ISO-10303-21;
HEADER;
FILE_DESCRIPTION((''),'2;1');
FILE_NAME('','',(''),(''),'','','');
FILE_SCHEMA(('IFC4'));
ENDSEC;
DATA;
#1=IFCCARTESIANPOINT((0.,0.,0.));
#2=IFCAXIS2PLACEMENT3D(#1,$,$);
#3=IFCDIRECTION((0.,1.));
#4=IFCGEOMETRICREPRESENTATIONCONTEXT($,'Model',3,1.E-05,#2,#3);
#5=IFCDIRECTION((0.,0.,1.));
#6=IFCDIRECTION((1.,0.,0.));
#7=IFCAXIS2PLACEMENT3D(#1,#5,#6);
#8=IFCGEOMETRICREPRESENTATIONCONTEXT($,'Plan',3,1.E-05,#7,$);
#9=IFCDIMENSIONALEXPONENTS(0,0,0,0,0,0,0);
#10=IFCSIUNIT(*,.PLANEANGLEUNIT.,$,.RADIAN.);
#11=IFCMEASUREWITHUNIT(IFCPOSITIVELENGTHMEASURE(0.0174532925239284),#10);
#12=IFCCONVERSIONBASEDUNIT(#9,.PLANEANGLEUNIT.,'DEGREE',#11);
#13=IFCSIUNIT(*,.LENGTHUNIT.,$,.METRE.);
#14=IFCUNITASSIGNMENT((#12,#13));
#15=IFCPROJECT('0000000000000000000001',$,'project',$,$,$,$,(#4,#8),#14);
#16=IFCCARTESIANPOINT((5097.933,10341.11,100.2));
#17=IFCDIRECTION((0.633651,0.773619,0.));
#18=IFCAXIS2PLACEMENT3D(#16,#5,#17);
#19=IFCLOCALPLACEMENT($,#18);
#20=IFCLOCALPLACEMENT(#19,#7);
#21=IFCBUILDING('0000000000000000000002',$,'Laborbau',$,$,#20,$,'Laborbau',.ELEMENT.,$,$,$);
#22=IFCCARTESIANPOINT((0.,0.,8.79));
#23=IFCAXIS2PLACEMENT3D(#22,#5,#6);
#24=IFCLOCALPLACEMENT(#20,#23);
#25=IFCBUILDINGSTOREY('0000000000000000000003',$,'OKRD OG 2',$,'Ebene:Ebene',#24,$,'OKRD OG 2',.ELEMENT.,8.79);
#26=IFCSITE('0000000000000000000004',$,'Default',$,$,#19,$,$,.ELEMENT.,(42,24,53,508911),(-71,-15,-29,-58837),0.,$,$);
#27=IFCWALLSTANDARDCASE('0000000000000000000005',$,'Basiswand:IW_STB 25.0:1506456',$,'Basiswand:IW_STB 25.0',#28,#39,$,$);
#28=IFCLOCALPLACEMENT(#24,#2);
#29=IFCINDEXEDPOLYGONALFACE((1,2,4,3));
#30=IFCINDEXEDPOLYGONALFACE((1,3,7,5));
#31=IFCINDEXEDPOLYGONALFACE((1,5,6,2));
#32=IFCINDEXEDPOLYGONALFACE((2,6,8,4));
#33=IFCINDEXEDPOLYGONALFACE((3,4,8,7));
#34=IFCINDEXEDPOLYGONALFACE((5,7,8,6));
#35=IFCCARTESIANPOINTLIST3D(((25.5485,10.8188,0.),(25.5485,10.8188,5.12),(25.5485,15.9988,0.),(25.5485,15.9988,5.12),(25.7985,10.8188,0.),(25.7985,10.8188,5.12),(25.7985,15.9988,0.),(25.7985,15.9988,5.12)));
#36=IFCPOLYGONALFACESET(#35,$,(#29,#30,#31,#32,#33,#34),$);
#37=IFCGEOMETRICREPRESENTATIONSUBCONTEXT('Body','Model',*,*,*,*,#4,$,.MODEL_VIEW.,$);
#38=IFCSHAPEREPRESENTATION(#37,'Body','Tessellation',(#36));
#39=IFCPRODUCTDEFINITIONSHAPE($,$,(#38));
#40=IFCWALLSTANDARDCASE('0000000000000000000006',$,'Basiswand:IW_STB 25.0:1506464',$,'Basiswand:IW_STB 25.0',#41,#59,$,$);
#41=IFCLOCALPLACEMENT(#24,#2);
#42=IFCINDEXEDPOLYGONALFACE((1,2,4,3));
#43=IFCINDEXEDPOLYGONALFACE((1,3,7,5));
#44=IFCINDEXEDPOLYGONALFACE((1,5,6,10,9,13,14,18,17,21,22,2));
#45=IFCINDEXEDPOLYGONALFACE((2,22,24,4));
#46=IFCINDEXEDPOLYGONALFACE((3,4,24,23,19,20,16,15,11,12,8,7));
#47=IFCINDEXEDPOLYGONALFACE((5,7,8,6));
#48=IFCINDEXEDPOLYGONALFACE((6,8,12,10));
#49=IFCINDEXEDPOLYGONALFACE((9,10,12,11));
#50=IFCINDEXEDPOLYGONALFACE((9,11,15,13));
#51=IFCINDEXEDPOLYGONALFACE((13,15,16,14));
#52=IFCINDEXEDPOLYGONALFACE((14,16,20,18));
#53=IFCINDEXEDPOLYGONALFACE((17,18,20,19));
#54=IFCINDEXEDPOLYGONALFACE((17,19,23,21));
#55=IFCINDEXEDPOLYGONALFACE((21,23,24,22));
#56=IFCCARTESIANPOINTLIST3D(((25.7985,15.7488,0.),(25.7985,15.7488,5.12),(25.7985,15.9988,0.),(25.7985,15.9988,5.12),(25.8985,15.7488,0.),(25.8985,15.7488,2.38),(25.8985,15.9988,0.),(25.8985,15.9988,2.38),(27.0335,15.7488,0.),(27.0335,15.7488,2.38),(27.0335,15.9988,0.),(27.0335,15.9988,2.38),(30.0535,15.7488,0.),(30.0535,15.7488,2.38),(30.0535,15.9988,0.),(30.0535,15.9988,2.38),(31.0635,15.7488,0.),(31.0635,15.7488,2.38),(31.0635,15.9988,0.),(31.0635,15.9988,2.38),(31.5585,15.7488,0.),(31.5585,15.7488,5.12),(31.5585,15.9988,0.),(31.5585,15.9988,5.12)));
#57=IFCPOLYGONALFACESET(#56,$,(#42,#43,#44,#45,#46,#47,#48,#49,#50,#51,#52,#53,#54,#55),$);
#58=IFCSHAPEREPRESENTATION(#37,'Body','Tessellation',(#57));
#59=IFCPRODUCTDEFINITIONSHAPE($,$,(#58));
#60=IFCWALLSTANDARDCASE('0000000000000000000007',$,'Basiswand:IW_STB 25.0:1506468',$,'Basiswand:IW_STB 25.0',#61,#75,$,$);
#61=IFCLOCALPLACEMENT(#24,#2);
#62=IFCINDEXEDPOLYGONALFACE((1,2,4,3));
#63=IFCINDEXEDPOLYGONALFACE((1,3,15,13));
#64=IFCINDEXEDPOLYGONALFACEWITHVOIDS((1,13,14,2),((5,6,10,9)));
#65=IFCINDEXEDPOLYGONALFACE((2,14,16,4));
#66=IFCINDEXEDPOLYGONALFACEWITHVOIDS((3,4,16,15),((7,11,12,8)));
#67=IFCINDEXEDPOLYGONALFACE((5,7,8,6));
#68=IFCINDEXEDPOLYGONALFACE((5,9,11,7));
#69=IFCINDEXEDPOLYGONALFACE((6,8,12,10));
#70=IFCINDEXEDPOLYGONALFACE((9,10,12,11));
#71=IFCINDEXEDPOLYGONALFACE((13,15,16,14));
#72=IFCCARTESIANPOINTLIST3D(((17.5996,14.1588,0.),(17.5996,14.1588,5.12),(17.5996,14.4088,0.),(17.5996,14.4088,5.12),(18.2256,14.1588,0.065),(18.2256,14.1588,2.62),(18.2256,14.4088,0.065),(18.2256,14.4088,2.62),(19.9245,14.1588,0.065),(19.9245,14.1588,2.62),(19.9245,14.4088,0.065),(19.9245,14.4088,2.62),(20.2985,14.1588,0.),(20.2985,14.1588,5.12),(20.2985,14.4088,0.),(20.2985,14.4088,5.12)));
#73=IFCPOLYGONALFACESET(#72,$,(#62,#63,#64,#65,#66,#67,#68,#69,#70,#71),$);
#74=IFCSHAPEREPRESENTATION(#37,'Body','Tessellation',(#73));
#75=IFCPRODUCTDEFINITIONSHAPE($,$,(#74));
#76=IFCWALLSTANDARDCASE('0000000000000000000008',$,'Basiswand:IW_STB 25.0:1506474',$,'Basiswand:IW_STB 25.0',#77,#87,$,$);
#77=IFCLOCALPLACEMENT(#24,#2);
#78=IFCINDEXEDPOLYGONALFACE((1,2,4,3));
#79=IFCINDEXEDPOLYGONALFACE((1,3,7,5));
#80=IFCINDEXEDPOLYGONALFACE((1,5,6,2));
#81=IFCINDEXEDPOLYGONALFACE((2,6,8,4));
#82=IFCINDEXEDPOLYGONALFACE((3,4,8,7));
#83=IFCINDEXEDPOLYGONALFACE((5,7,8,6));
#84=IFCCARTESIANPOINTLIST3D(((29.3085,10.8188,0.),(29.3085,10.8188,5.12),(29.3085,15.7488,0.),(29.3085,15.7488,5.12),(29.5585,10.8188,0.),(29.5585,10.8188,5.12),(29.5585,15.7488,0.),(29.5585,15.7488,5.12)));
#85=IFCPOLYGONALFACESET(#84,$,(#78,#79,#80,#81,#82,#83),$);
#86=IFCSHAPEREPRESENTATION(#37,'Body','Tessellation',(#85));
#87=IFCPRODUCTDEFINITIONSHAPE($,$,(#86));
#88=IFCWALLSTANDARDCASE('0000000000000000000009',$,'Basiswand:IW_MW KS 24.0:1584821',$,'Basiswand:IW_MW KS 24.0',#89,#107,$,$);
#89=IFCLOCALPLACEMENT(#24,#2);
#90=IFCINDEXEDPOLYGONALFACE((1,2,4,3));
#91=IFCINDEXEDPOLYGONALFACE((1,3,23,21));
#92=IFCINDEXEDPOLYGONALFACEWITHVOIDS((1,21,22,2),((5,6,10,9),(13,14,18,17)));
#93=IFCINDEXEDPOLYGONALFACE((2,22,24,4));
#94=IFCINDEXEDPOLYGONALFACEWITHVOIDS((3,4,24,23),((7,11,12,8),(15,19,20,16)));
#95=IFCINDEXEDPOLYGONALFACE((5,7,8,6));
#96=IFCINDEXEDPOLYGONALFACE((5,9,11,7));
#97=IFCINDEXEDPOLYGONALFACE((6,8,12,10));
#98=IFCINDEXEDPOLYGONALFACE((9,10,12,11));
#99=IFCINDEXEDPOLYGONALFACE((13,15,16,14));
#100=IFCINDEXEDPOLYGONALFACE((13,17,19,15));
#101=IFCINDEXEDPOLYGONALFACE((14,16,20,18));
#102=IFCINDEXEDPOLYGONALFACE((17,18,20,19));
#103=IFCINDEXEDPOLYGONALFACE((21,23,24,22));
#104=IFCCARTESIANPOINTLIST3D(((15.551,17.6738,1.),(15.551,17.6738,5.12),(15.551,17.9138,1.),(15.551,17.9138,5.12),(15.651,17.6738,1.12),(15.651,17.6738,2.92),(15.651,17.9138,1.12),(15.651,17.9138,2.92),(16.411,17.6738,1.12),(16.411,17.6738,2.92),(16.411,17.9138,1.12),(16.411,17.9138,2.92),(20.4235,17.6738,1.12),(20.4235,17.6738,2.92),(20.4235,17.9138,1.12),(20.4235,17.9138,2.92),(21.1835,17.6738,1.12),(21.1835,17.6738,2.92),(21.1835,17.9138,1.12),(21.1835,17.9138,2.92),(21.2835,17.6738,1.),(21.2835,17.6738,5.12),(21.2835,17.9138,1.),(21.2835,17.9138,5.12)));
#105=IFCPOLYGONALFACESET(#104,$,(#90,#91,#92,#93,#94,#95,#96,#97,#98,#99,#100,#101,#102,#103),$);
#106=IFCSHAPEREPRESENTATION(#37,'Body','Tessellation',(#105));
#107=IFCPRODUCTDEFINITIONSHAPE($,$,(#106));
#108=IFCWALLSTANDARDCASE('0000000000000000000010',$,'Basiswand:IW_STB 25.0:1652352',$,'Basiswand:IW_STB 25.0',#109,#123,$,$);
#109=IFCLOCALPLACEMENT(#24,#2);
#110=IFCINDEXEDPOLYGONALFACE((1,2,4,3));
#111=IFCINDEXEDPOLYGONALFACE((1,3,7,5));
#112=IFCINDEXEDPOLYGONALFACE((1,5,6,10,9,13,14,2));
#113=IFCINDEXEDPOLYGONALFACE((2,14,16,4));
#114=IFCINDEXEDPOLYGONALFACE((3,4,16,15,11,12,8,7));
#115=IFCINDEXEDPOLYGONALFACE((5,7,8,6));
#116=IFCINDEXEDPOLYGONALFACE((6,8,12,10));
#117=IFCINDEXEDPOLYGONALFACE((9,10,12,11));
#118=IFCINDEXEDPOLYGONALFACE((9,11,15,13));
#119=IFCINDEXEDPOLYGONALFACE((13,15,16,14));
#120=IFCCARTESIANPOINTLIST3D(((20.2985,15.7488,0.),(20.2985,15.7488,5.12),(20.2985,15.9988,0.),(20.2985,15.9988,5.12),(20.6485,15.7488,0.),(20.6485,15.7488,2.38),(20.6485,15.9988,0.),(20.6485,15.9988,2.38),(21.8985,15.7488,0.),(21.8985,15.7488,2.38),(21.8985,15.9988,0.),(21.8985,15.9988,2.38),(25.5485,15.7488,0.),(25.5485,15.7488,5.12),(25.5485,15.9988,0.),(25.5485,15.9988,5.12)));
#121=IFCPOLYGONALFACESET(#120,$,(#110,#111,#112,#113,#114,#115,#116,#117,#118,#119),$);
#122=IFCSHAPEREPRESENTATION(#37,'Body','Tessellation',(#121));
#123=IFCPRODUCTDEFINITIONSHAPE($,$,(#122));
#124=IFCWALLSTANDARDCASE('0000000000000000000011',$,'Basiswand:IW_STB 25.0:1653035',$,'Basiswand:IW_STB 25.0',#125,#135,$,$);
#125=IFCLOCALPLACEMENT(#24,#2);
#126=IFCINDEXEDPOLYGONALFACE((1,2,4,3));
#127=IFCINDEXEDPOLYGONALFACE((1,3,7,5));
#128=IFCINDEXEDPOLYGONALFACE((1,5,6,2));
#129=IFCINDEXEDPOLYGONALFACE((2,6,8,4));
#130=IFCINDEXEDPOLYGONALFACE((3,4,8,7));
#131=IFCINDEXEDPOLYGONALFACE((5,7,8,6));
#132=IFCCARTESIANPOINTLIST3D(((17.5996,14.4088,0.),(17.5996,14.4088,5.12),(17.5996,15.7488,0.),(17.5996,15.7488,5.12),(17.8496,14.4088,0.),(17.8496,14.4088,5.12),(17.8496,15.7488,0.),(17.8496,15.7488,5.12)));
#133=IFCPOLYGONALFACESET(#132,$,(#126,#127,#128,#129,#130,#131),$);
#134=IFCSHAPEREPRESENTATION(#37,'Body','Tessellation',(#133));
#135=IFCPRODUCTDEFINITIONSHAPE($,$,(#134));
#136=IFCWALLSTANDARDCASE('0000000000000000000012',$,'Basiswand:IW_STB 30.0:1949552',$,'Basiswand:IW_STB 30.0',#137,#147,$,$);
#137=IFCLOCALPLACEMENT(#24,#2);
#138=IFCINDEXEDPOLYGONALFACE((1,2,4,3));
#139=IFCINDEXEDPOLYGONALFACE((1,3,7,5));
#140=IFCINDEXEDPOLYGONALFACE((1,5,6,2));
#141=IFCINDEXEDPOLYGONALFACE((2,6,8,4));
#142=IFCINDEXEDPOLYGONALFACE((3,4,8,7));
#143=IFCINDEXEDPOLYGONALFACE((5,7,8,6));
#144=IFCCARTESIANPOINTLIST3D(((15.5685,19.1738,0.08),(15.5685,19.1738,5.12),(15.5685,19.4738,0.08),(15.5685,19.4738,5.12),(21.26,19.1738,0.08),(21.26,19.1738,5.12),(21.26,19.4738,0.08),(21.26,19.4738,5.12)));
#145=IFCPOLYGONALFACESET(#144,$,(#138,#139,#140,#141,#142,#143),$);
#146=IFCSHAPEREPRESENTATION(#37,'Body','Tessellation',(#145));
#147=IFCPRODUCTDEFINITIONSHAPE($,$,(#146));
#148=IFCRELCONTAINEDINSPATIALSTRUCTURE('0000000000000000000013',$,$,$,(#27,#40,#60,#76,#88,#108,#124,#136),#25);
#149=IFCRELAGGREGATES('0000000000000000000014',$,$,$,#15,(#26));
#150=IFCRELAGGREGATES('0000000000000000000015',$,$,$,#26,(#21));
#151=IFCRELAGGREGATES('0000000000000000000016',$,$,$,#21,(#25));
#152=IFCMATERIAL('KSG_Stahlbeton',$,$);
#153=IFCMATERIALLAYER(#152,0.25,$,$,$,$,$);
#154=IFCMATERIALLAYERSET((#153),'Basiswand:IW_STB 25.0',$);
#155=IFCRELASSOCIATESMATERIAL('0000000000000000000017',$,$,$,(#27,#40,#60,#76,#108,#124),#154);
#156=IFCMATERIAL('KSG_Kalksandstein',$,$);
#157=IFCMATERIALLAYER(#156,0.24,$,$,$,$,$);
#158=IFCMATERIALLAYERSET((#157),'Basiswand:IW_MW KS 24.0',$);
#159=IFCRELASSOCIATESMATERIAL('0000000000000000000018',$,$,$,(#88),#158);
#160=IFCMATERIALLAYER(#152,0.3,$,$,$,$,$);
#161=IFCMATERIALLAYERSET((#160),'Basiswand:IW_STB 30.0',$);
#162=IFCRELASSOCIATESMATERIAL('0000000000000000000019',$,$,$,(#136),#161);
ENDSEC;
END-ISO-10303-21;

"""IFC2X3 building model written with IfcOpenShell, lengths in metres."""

from ifc_helpers import new_model, entity, si_unit, converted_unit, direction, frame, frame_2d, origin, origin_with_axes, place, context, subcontext, project, spatial, rectangle, extrude, material, layer, layer_set, layer_usage, element, save


model = new_model("IFC2X3")

# Units and contexts
model_context = context("Model", 3, precision=1e-05, world=origin(), true_north=direction((0.0, 1.0)))
plan_context = context("Plan", 3, precision=1e-05, world=origin_with_axes())
body_context = subcontext(model_context, "Body", "Model", "MODEL_VIEW")
ifc_project = project(units=[converted_unit("PLANEANGLEUNIT", "DEGREE", entity("IfcPositiveLengthMeasure", 0.0174532925239284), si_unit("PLANEANGLEUNIT", "RADIAN"), dimensions=[0, 0, 0, 0, 0, 0, 0]), si_unit("LENGTHUNIT", "METRE")], contexts=[model_context, plan_context])

# Site, building, storey
site_placement = place(None, frame((5097.933, 10341.11, 100.2), z_axis=(0.0, 0.0, 1.0), x_axis=(0.633651, 0.773619, 0.0)))
site = spatial("IfcSite", under=ifc_project, at=site_placement, Name="Default", CompositionType="ELEMENT", RefLatitude=(42, 24, 53, 508911), RefLongitude=(-71, -15, -29, -58837), RefElevation=0.0)
building_placement = place(site_placement, origin_with_axes())
building = spatial("IfcBuilding", under=site, at=building_placement, Name="Laborbau", LongName="Laborbau", CompositionType="ELEMENT")
storey_placement = place(building_placement, frame((0.0, 0.0, 8.79), z_axis=(0.0, 0.0, 1.0), x_axis=(1.0, 0.0, 0.0)))
storey = spatial("IfcBuildingStorey", under=building, at=storey_placement, Name="OKRD OG 2", ObjectType="Ebene:Ebene", LongName="OKRD OG 2", CompositionType="ELEMENT", Elevation=8.79)

# Shared definitions
ifc_material_1 = material(Name="KSG_Kalksandstein")
ifc_layer_1 = layer(ifc_material_1, 0.24)
ifc_layer_set_1 = layer_set([ifc_layer_1], Name="Basiswand:IW_MW KS 24.0")

# Wall
ifc_material_2 = material(Name="KSG_Stahlbeton")
ifc_layer_2 = layer(ifc_material_2, 0.25)
ifc_layer_set_2 = layer_set([ifc_layer_2], Name="Basiswand:IW_STB 25.0")
ifc_layer_usage_1 = layer_usage(ifc_layer_set_2, "AXIS2", "NEGATIVE", 0.125)
wall_1_placement = place(storey_placement, frame((25.6735, 10.8188, 0.0), z_axis=(0.0, 0.0, 1.0), x_axis=(0.0, 1.0, 0.0)))
element("IfcWallStandardCase", 1, at=wall_1_placement, inside=storey, material=ifc_layer_usage_1, Name="Basiswand:IW_STB 25.0:1506456", ObjectType="Basiswand:IW_STB 25.0", context=body_context, shape_type="SweptSolid", body=[
    extrude(rectangle(XDim=5.18, YDim=0.25, at=frame_2d((2.59, 0.0), x_axis=(-1.0, 0.0))), origin(), (0.0, 0.0, 1.0), 5.12),
])

# Wall, openings
ifc_layer_usage_2 = layer_usage(ifc_layer_set_2, "AXIS2", "NEGATIVE", 0.125)
wall_2_placement = place(storey_placement, frame((25.7985, 15.8738, 0.0), z_axis=(0.0, 0.0, 1.0), x_axis=(1.0, 0.0, 0.0)))
wall_2 = element("IfcWallStandardCase", 2, at=wall_2_placement, inside=storey, material=ifc_layer_usage_2, Name="Basiswand:IW_STB 25.0:1506464", ObjectType="Basiswand:IW_STB 25.0", context=body_context, shape_type="SweptSolid", body=[
    extrude(rectangle(XDim=5.76, YDim=0.25, at=frame_2d((2.88, 0.0), x_axis=(-1.0, 0.0))), origin(), (0.0, 0.0, 1.0), 5.12),
])
opening_1_placement = place(wall_2_placement, frame((-25.7985, -15.8738, 0.0), z_axis=(0.0, 0.0, 1.0), x_axis=(1.0, 0.0, 0.0)))
element("IfcOpeningElement", 3, at=opening_1_placement, cuts=wall_2, ObjectType="Opening", context=body_context, shape_type="SweptSolid", body=[
    extrude(rectangle(XDim=2.38, YDim=1.135, at=frame_2d((0.0, 0.0), x_axis=(0.0, 1.0))), frame((26.466, 14.4748, 1.19), z_axis=(0.0, 1.0, 0.0), x_axis=(-1.0, 0.0, 0.0)), (0.0, 0.0, 1.0), 3.048),
])
opening_2_placement = place(wall_2_placement, frame((1.235, 0.125, 0.0), z_axis=(0.0, 0.0, 1.0), x_axis=(1.0, 0.0, 0.0)))
element("IfcOpeningElement", 4, at=opening_2_placement, cuts=wall_2, ObjectType="Opening", context=body_context, shape_type="SweptSolid", body=[
    extrude(rectangle(XDim=2.38, YDim=1.135, at=frame_2d((1.19, 0.5675), x_axis=(1.0, 0.0))), frame((0.0, 0.0, 0.0), z_axis=(0.0, -1.0, 0.0), x_axis=(0.0, 0.0, 1.0)), (0.0, 0.0, 1.0), 0.25),
])
opening_3_placement = place(wall_2_placement, frame((-25.7985, -15.8738, 0.0), z_axis=(0.0, 0.0, 1.0), x_axis=(1.0, 0.0, 0.0)))
element("IfcOpeningElement", 5, at=opening_3_placement, cuts=wall_2, ObjectType="Opening", context=body_context, shape_type="SweptSolid", body=[
    extrude(rectangle(XDim=2.38, YDim=1.01, at=frame_2d((0.0, 0.0), x_axis=(0.0, 1.0))), frame((30.5585, 14.2248, 1.19), z_axis=(0.0, 1.0, 0.0), x_axis=(-1.0, 0.0, 0.0)), (0.0, 0.0, 1.0), 3.048),
])
opening_4_placement = place(wall_2_placement, frame((4.255, -0.125, 0.0), z_axis=(0.0, 0.0, 1.0), x_axis=(1.0, 0.0, 0.0)))
element("IfcOpeningElement", 6, at=opening_4_placement, cuts=wall_2, ObjectType="Opening", context=body_context, shape_type="SweptSolid", body=[
    extrude(rectangle(XDim=2.38, YDim=1.01, at=frame_2d((1.19, 0.505), x_axis=(1.0, 0.0))), frame((0.0, 0.0, 0.0), z_axis=(0.0, 1.0, 0.0), x_axis=(0.0, 0.0, 1.0)), (0.0, 0.0, 1.0), 0.25),
])

# Wall, opening
ifc_layer_usage_3 = layer_usage(ifc_layer_set_2, "AXIS2", "NEGATIVE", 0.125)
wall_3_placement = place(storey_placement, frame((17.5996, 14.2838, 0.0), z_axis=(0.0, 0.0, 1.0), x_axis=(1.0, 0.0, 0.0)))
wall_3 = element("IfcWallStandardCase", 7, at=wall_3_placement, inside=storey, material=ifc_layer_usage_3, Name="Basiswand:IW_STB 25.0:1506468", ObjectType="Basiswand:IW_STB 25.0", context=body_context, shape_type="SweptSolid", body=[
    extrude(rectangle(XDim=2.699, YDim=0.25, at=frame_2d((1.3495, 0.0), x_axis=(-1.0, 0.0))), origin(), (0.0, 0.0, 1.0), 5.12),
])
opening_5_placement = place(wall_3_placement, origin_with_axes())
element("IfcOpeningElement", 8, at=opening_5_placement, cuts=wall_3, ObjectType="Opening", context=body_context, shape_type="SweptSolid", body=[
    extrude(rectangle(XDim=2.555, YDim=1.699, at=frame_2d((0.0, 0.0), x_axis=(1.0, 0.0))), frame((1.4755, -0.125, 1.3425), z_axis=(0.0, 1.0, 0.0), x_axis=(0.0, 0.0, -1.0)), (0.0, 0.0, 1.0), 0.25),
])

# Wall
ifc_layer_usage_4 = layer_usage(ifc_layer_set_2, "AXIS2", "NEGATIVE", 0.125)
wall_4_placement = place(storey_placement, frame((29.4335, 10.8188, 0.0), z_axis=(0.0, 0.0, 1.0), x_axis=(0.0, 1.0, 0.0)))
element("IfcWallStandardCase", 9, at=wall_4_placement, inside=storey, material=ifc_layer_usage_4, Name="Basiswand:IW_STB 25.0:1506474", ObjectType="Basiswand:IW_STB 25.0", context=body_context, shape_type="SweptSolid", body=[
    extrude(rectangle(XDim=4.93, YDim=0.25, at=frame_2d((2.465, 0.0), x_axis=(-1.0, 0.0))), origin(), (0.0, 0.0, 1.0), 5.12),
])

# Walls, openings
ifc_layer_usage_5 = layer_usage(ifc_layer_set_1, "AXIS2", "NEGATIVE", 0.12)
wall_5_placement = place(storey_placement, frame((21.2835, 17.7938, 1.0), z_axis=(0.0, 0.0, 1.0), x_axis=(-1.0, 0.0, 0.0)))
wall_5 = element("IfcWallStandardCase", 10, at=wall_5_placement, inside=storey, material=ifc_layer_usage_5, Name="Basiswand:IW_MW KS 24.0:1584821", ObjectType="Basiswand:IW_MW KS 24.0", context=body_context, shape_type="SweptSolid", body=[
    extrude(rectangle(XDim=5.7325, YDim=0.24, at=frame_2d((2.8663, 0.0), x_axis=(-1.0, 0.0))), origin(), (0.0, 0.0, 1.0), 4.12),
])
opening_6_placement = place(wall_5_placement, frame((21.2835, 17.7938, -1.0), z_axis=(0.0, 0.0, 1.0), x_axis=(-1.0, 0.0, 0.0)))
element("IfcOpeningElement", 11, at=opening_6_placement, cuts=wall_5, ObjectType="Opening", context=body_context, shape_type="SweptSolid", body=[
    extrude(rectangle(XDim=1.8, YDim=0.76, at=frame_2d((0.0, 0.0), x_axis=(1.0, 0.0))), frame((16.031, 19.4378, 2.02), z_axis=(0.0, -1.0, 0.0), x_axis=(0.0, 0.0, 1.0)), (0.0, 0.0, 1.0), 3.048),
])
opening_7_placement = place(wall_5_placement, frame((4.8725, -0.12, 0.12), z_axis=(0.0, 0.0, 1.0), x_axis=(1.0, 0.0, 0.0)))
element("IfcOpeningElement", 12, at=opening_7_placement, cuts=wall_5, ObjectType="Opening", context=body_context, shape_type="SweptSolid", body=[
    extrude(rectangle(XDim=1.8, YDim=0.76, at=frame_2d((0.9, 0.38), x_axis=(1.0, 0.0))), frame((0.0, 0.0, 0.0), z_axis=(0.0, 1.0, 0.0), x_axis=(0.0, 0.0, 1.0)), (0.0, 0.0, 1.0), 0.24),
])
opening_8_placement = place(wall_5_placement, frame((21.2835, 17.7938, -1.0), z_axis=(0.0, 0.0, 1.0), x_axis=(-1.0, 0.0, 0.0)))
element("IfcOpeningElement", 13, at=opening_8_placement, cuts=wall_5, ObjectType="Opening", context=body_context, shape_type="SweptSolid", body=[
    extrude(rectangle(XDim=1.8, YDim=0.76, at=frame_2d((0.0, 0.0), x_axis=(0.0, 1.0))), frame((20.8035, 19.4378, 2.02), z_axis=(0.0, -1.0, 0.0), x_axis=(1.0, 0.0, 0.0)), (0.0, 0.0, 1.0), 3.048),
])
opening_9_placement = place(wall_5_placement, frame((0.1, -0.12, 0.12), z_axis=(0.0, 0.0, 1.0), x_axis=(1.0, 0.0, 0.0)))
element("IfcOpeningElement", 14, at=opening_9_placement, cuts=wall_5, ObjectType="Opening", context=body_context, shape_type="SweptSolid", body=[
    extrude(rectangle(XDim=1.8, YDim=0.76, at=frame_2d((0.9, 0.38), x_axis=(1.0, 0.0))), frame((0.0, 0.0, 0.0), z_axis=(0.0, 1.0, 0.0), x_axis=(0.0, 0.0, 1.0)), (0.0, 0.0, 1.0), 0.24),
])
ifc_layer_usage_6 = layer_usage(ifc_layer_set_2, "AXIS2", "NEGATIVE", 0.125)
wall_6_placement = place(storey_placement, frame((20.2985, 15.8738, 0.0), z_axis=(0.0, 0.0, 1.0), x_axis=(1.0, 0.0, 0.0)))
wall_6 = element("IfcWallStandardCase", 15, at=wall_6_placement, inside=storey, material=ifc_layer_usage_6, Name="Basiswand:IW_STB 25.0:1652352", ObjectType="Basiswand:IW_STB 25.0", context=body_context, shape_type="SweptSolid", body=[
    extrude(rectangle(XDim=5.25, YDim=0.25, at=frame_2d((2.625, 0.0), x_axis=(-1.0, 0.0))), origin(), (0.0, 0.0, 1.0), 5.12),
])
opening_10_placement = place(wall_6_placement, frame((-20.2985, -15.8738, 0.0), z_axis=(0.0, 0.0, 1.0), x_axis=(1.0, 0.0, 0.0)))
element("IfcOpeningElement", 16, at=opening_10_placement, cuts=wall_6, ObjectType="Opening", context=body_context, shape_type="SweptSolid", body=[
    extrude(rectangle(XDim=2.38, YDim=1.25, at=frame_2d((0.0, 0.0), x_axis=(0.0, 1.0))), frame((21.2735, 14.4748, 1.19), z_axis=(0.0, 1.0, 0.0), x_axis=(-1.0, 0.0, 0.0)), (0.0, 0.0, 1.0), 3.048),
])
opening_11_placement = place(wall_6_placement, frame((1.6, 0.125, 0.0), z_axis=(0.0, 0.0, 1.0), x_axis=(1.0, 0.0, 0.0)))
element("IfcOpeningElement", 17, at=opening_11_placement, cuts=wall_6, ObjectType="Opening", context=body_context, shape_type="SweptSolid", body=[
    extrude(rectangle(XDim=2.38, YDim=1.25, at=frame_2d((1.19, 0.625), x_axis=(1.0, 0.0))), frame((0.0, 0.0, 0.0), z_axis=(0.0, -1.0, 0.0), x_axis=(0.0, 0.0, 1.0)), (0.0, 0.0, 1.0), 0.25),
])

# Walls
ifc_layer_usage_7 = layer_usage(ifc_layer_set_2, "AXIS2", "NEGATIVE", 0.125)
wall_7_placement = place(storey_placement, frame((17.7246, 14.4088, 0.0), z_axis=(0.0, 0.0, 1.0), x_axis=(0.0, 1.0, 0.0)))
element("IfcWallStandardCase", 18, at=wall_7_placement, inside=storey, material=ifc_layer_usage_7, Name="Basiswand:IW_STB 25.0:1653035", ObjectType="Basiswand:IW_STB 25.0", context=body_context, shape_type="SweptSolid", body=[
    extrude(rectangle(XDim=1.34, YDim=0.25, at=frame_2d((0.67, 0.0), x_axis=(-1.0, 0.0))), origin(), (0.0, 0.0, 1.0), 5.12),
])
ifc_layer_3 = layer(ifc_material_2, 0.3)
ifc_layer_set_3 = layer_set([ifc_layer_3], Name="Basiswand:IW_STB 30.0")
ifc_layer_usage_8 = layer_usage(ifc_layer_set_3, "AXIS2", "POSITIVE", -0.15)
wall_8_placement = place(storey_placement, frame((21.26, 19.3238, 0.08), z_axis=(0.0, 0.0, 1.0), x_axis=(-1.0, 0.0, 0.0)))
element("IfcWallStandardCase", 19, at=wall_8_placement, inside=storey, material=ifc_layer_usage_8, Name="Basiswand:IW_STB 30.0:1949552", ObjectType="Basiswand:IW_STB 30.0", context=body_context, shape_type="SweptSolid", body=[
    extrude(rectangle(XDim=5.6915, YDim=0.3, at=frame_2d((2.8457, 0.0), x_axis=(-1.0, 0.0))), origin(), (0.0, 0.0, 1.0), 5.04),
])

save(model, "model.ifc")
